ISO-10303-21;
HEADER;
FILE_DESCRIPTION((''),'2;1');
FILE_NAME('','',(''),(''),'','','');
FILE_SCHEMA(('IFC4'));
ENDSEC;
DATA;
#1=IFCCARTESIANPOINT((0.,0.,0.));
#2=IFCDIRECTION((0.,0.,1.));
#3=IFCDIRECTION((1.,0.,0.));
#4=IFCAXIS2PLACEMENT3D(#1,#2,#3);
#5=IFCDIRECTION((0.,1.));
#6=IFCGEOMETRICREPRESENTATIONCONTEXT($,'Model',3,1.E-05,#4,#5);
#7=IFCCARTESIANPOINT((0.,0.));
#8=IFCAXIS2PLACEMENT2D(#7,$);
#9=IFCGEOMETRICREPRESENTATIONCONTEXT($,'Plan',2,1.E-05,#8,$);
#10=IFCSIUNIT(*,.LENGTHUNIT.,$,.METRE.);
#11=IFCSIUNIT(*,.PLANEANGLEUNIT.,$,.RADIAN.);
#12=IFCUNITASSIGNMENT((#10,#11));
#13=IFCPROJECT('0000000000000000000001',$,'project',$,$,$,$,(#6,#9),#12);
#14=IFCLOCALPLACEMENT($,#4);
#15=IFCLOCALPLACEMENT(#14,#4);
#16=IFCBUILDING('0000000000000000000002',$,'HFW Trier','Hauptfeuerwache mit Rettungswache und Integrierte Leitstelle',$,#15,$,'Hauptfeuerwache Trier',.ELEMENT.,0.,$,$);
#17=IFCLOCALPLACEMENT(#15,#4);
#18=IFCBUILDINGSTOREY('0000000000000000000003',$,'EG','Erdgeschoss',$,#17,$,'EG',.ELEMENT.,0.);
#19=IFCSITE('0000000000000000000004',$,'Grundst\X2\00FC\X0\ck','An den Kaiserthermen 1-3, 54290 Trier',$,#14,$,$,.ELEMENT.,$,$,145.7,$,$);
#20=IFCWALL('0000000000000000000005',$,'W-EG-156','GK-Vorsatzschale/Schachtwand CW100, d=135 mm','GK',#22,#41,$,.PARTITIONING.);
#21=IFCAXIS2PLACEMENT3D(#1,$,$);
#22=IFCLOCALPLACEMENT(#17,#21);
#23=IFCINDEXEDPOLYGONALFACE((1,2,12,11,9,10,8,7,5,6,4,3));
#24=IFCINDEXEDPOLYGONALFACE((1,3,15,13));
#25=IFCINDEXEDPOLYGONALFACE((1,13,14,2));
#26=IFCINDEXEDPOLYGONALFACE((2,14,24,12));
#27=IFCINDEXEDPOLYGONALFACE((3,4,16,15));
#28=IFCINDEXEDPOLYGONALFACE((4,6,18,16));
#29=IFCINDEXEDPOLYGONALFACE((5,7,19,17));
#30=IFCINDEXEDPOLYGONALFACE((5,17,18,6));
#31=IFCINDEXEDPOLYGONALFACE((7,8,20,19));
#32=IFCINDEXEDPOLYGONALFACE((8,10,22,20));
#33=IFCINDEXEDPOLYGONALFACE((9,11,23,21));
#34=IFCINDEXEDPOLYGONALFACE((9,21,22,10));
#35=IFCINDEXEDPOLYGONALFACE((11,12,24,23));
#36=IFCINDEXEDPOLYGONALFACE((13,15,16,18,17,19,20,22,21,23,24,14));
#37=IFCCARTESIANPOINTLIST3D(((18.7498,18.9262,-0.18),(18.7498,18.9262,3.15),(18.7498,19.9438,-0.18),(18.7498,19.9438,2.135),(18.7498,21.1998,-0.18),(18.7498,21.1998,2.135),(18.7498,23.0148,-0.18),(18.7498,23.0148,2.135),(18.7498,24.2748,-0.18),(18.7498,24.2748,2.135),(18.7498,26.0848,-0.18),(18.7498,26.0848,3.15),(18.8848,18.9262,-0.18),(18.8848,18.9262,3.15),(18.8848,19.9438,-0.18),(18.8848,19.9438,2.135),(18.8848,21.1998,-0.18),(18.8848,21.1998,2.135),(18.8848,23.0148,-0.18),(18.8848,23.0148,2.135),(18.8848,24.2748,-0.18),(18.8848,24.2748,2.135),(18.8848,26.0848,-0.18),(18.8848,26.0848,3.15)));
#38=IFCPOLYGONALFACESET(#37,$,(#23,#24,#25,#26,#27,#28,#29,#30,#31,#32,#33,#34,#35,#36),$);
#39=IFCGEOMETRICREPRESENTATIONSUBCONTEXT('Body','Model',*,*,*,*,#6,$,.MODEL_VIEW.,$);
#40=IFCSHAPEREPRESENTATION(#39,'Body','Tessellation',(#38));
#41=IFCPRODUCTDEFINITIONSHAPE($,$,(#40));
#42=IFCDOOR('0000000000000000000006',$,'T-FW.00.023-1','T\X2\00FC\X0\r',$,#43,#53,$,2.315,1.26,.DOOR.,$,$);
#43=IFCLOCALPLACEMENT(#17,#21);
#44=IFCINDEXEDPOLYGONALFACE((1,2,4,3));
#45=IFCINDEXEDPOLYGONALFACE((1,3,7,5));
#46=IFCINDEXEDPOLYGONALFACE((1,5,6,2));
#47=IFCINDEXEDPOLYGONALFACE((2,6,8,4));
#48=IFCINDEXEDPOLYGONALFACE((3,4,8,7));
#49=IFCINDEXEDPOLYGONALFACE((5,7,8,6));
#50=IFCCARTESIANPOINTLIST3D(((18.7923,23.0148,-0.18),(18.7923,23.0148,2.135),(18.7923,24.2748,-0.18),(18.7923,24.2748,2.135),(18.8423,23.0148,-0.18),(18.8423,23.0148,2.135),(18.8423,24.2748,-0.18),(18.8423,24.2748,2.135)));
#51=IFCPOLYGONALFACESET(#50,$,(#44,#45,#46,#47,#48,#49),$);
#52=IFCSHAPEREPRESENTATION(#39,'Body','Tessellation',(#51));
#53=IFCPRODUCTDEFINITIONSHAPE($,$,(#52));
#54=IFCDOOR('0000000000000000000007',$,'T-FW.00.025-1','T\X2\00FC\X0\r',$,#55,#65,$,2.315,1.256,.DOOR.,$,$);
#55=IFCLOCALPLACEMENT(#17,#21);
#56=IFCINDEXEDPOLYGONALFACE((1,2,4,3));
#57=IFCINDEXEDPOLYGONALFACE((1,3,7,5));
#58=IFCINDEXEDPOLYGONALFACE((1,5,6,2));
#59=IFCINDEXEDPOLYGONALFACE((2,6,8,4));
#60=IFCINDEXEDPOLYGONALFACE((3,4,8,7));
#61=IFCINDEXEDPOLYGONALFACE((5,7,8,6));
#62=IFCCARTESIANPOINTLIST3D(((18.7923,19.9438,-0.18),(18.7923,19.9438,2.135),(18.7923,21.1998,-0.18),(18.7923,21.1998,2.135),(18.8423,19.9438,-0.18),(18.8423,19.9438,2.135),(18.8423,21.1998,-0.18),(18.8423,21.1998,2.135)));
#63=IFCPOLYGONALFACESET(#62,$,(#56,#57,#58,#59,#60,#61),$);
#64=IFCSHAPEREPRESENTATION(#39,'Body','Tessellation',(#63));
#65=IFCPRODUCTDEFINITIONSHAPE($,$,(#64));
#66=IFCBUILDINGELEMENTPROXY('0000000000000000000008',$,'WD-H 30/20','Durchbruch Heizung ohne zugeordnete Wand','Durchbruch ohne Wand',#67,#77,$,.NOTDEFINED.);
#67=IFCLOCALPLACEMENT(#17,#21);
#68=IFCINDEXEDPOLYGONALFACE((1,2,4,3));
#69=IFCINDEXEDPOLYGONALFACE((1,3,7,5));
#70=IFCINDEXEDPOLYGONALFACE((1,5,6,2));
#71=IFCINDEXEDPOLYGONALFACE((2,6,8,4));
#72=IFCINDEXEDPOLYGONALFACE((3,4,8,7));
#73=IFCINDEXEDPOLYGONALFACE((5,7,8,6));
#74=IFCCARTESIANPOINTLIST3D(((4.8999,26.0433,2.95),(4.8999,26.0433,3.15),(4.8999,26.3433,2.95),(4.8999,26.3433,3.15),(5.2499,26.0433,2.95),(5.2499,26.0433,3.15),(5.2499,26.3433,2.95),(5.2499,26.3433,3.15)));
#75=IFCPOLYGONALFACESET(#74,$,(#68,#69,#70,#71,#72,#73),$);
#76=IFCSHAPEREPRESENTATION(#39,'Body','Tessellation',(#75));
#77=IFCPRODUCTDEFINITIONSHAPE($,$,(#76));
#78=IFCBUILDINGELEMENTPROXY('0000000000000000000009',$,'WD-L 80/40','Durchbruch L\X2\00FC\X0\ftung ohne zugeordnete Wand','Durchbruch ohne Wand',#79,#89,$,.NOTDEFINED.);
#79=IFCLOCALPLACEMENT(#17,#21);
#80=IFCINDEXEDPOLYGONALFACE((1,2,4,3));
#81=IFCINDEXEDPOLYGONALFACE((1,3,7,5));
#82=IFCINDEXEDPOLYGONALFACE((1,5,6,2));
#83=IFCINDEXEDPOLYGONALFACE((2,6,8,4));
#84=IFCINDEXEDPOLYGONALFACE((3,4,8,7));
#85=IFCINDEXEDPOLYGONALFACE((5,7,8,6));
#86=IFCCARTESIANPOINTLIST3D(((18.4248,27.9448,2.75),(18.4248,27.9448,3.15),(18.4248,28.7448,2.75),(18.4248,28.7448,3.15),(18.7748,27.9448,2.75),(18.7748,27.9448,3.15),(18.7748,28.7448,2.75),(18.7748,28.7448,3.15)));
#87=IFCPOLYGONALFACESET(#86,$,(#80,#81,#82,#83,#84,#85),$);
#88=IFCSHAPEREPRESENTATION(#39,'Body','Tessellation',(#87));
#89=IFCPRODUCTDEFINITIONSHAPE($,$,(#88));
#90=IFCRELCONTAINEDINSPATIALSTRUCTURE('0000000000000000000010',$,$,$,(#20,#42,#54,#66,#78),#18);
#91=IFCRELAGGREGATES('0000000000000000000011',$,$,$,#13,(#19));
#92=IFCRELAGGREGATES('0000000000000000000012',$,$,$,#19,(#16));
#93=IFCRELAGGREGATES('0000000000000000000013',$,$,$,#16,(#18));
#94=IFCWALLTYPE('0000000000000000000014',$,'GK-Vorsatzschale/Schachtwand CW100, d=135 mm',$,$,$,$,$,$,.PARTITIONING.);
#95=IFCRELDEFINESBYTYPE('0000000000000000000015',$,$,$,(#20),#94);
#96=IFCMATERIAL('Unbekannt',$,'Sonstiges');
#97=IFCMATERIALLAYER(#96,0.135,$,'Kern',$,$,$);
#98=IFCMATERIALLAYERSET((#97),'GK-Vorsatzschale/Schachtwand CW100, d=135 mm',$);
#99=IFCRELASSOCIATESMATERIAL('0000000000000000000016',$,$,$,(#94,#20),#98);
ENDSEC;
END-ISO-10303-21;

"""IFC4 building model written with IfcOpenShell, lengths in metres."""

from ifc_helpers import new_model, si_unit, direction, frame, frame_2d, origin_with_axes, origin_2d, place, context, subcontext, project, spatial, rectangle, extrude, material, layer, layer_set, layer_usage, type_object, element, fill, save


model = new_model("IFC4")

# Units and contexts
model_context = context("Model", 3, precision=1e-05, world=origin_with_axes(), true_north=direction((0.0, 1.0)))
plan_context = context("Plan", 2, precision=1e-05, world=origin_2d())
body_context = subcontext(model_context, "Body", "Model", "MODEL_VIEW")
ifc_project = project(units=[si_unit("LENGTHUNIT", "METRE"), si_unit("PLANEANGLEUNIT", "RADIAN")], contexts=[model_context, plan_context])

# Site, building, storey
site_placement = place(None, origin_with_axes())
site = spatial("IfcSite", under=ifc_project, at=site_placement, Name="Grundstück", Description="An den Kaiserthermen 1-3, 54290 Trier", CompositionType="ELEMENT", RefElevation=145.7)
building_placement = place(site_placement, origin_with_axes())
building = spatial("IfcBuilding", under=site, at=building_placement, Name="HFW Trier", Description="Hauptfeuerwache mit Rettungswache und Integrierte Leitstelle", LongName="Hauptfeuerwache Trier", CompositionType="ELEMENT", ElevationOfRefHeight=0.0)
storey_placement = place(building_placement, origin_with_axes())
storey = spatial("IfcBuildingStorey", under=building, at=storey_placement, Name="EG", Description="Erdgeschoss", LongName="EG", CompositionType="ELEMENT", Elevation=0.0)

# Wall, openings, doors
ifc_material_1 = material(Name="Unbekannt", Category="Sonstiges")
ifc_layer_1 = layer(ifc_material_1, 0.135, Name="Kern")
ifc_layer_set_1 = layer_set([ifc_layer_1], Name="GK-Vorsatzschale/Schachtwand CW100, d=135 mm")
ifc_layer_usage_1 = layer_usage(ifc_layer_set_1, "AXIS2", "POSITIVE", -0.0675)
wall_type_1 = type_object("IfcWallType", Name="GK-Vorsatzschale/Schachtwand CW100, d=135 mm", PredefinedType="PARTITIONING", material=ifc_layer_set_1)
wall_1_placement = place(storey_placement, frame((18.8173, 26.0848, -0.18), z_axis=(0.0, 0.0, 1.0), x_axis=(0.0, -1.0, 0.0)))
wall_1 = element("IfcWall", 1, at=wall_1_placement, inside=storey, type_object=wall_type_1, material=ifc_layer_usage_1, Name="W-EG-156", Description="GK-Vorsatzschale/Schachtwand CW100, d=135 mm", ObjectType="GK", PredefinedType="PARTITIONING", context=body_context, shape_type="SweptSolid", body=[
    extrude(rectangle(XDim=7.1586, YDim=0.135, at=frame_2d((3.5793, 0.0))), origin_with_axes(), (0.0, 0.0, 1.0), 3.33),
])
opening_1_placement = place(wall_1_placement, frame((1.81, 0.0, 0.0), z_axis=(0.0, 0.0, 1.0), x_axis=(1.0, 0.0, 0.0)))
opening_1 = element("IfcOpeningElement", 2, at=opening_1_placement, cuts=wall_1, PredefinedType="OPENING", context=body_context, shape_type="SweptSolid", body=[
    extrude(rectangle(XDim=1.26, YDim=0.235, at=frame_2d((0.63, 0.0))), origin_with_axes(), (0.0, 0.0, 1.0), 2.315),
])
opening_2_placement = place(wall_1_placement, frame((4.885, 0.0, 0.0), z_axis=(0.0, 0.0, 1.0), x_axis=(1.0, 0.0, 0.0)))
opening_2 = element("IfcOpeningElement", 3, at=opening_2_placement, cuts=wall_1, PredefinedType="OPENING", context=body_context, shape_type="SweptSolid", body=[
    extrude(rectangle(XDim=1.256, YDim=0.235, at=frame_2d((0.628, 0.0))), origin_with_axes(), (0.0, 0.0, 1.0), 2.315),
])
door_1_placement = place(wall_1_placement, frame((1.81, 0.0, 0.0), z_axis=(0.0, 0.0, 1.0), x_axis=(1.0, 0.0, 0.0)))
door_1 = element("IfcDoor", 4, at=door_1_placement, inside=storey, Name="T-FW.00.023-1", Description="Tür", OverallHeight=2.315, OverallWidth=1.26, PredefinedType="DOOR", context=body_context, shape_type="SweptSolid", body=[
    extrude(rectangle(XDim=1.26, YDim=0.05, at=frame_2d((0.63, 0.0))), origin_with_axes(), (0.0, 0.0, 1.0), 2.315),
])
fill(opening_1, door_1)
door_2_placement = place(wall_1_placement, frame((4.885, 0.0, 0.0), z_axis=(0.0, 0.0, 1.0), x_axis=(1.0, 0.0, 0.0)))
door_2 = element("IfcDoor", 5, at=door_2_placement, inside=storey, Name="T-FW.00.025-1", Description="Tür", OverallHeight=2.315, OverallWidth=1.256, PredefinedType="DOOR", context=body_context, shape_type="SweptSolid", body=[
    extrude(rectangle(XDim=1.256, YDim=0.05, at=frame_2d((0.628, 0.0))), origin_with_axes(), (0.0, 0.0, 1.0), 2.315),
])
fill(opening_2, door_2)

# Building element proxies
proxy_1_placement = place(storey_placement, frame((5.0749, 26.1933, 2.95), z_axis=(0.0, 0.0, 1.0), x_axis=(0.0, 1.0, 0.0)))
element("IfcBuildingElementProxy", 6, at=proxy_1_placement, inside=storey, Name="WD-H 30/20", Description="Durchbruch Heizung ohne zugeordnete Wand", ObjectType="Durchbruch ohne Wand", PredefinedType="NOTDEFINED", context=body_context, shape_type="SweptSolid", body=[
    extrude(rectangle(XDim=0.3, YDim=0.35, at=origin_2d()), origin_with_axes(), (0.0, 0.0, 1.0), 0.2),
])
proxy_2_placement = place(storey_placement, frame((18.5998, 28.3448, 2.75), z_axis=(0.0, 0.0, 1.0), x_axis=(0.0, 1.0, 0.0)))
element("IfcBuildingElementProxy", 7, at=proxy_2_placement, inside=storey, Name="WD-L 80/40", Description="Durchbruch Lüftung ohne zugeordnete Wand", ObjectType="Durchbruch ohne Wand", PredefinedType="NOTDEFINED", context=body_context, shape_type="SweptSolid", body=[
    extrude(rectangle(XDim=0.8, YDim=0.35, at=origin_2d()), origin_with_axes(), (0.0, 0.0, 1.0), 0.4),
])

save(model, "model.ifc")
